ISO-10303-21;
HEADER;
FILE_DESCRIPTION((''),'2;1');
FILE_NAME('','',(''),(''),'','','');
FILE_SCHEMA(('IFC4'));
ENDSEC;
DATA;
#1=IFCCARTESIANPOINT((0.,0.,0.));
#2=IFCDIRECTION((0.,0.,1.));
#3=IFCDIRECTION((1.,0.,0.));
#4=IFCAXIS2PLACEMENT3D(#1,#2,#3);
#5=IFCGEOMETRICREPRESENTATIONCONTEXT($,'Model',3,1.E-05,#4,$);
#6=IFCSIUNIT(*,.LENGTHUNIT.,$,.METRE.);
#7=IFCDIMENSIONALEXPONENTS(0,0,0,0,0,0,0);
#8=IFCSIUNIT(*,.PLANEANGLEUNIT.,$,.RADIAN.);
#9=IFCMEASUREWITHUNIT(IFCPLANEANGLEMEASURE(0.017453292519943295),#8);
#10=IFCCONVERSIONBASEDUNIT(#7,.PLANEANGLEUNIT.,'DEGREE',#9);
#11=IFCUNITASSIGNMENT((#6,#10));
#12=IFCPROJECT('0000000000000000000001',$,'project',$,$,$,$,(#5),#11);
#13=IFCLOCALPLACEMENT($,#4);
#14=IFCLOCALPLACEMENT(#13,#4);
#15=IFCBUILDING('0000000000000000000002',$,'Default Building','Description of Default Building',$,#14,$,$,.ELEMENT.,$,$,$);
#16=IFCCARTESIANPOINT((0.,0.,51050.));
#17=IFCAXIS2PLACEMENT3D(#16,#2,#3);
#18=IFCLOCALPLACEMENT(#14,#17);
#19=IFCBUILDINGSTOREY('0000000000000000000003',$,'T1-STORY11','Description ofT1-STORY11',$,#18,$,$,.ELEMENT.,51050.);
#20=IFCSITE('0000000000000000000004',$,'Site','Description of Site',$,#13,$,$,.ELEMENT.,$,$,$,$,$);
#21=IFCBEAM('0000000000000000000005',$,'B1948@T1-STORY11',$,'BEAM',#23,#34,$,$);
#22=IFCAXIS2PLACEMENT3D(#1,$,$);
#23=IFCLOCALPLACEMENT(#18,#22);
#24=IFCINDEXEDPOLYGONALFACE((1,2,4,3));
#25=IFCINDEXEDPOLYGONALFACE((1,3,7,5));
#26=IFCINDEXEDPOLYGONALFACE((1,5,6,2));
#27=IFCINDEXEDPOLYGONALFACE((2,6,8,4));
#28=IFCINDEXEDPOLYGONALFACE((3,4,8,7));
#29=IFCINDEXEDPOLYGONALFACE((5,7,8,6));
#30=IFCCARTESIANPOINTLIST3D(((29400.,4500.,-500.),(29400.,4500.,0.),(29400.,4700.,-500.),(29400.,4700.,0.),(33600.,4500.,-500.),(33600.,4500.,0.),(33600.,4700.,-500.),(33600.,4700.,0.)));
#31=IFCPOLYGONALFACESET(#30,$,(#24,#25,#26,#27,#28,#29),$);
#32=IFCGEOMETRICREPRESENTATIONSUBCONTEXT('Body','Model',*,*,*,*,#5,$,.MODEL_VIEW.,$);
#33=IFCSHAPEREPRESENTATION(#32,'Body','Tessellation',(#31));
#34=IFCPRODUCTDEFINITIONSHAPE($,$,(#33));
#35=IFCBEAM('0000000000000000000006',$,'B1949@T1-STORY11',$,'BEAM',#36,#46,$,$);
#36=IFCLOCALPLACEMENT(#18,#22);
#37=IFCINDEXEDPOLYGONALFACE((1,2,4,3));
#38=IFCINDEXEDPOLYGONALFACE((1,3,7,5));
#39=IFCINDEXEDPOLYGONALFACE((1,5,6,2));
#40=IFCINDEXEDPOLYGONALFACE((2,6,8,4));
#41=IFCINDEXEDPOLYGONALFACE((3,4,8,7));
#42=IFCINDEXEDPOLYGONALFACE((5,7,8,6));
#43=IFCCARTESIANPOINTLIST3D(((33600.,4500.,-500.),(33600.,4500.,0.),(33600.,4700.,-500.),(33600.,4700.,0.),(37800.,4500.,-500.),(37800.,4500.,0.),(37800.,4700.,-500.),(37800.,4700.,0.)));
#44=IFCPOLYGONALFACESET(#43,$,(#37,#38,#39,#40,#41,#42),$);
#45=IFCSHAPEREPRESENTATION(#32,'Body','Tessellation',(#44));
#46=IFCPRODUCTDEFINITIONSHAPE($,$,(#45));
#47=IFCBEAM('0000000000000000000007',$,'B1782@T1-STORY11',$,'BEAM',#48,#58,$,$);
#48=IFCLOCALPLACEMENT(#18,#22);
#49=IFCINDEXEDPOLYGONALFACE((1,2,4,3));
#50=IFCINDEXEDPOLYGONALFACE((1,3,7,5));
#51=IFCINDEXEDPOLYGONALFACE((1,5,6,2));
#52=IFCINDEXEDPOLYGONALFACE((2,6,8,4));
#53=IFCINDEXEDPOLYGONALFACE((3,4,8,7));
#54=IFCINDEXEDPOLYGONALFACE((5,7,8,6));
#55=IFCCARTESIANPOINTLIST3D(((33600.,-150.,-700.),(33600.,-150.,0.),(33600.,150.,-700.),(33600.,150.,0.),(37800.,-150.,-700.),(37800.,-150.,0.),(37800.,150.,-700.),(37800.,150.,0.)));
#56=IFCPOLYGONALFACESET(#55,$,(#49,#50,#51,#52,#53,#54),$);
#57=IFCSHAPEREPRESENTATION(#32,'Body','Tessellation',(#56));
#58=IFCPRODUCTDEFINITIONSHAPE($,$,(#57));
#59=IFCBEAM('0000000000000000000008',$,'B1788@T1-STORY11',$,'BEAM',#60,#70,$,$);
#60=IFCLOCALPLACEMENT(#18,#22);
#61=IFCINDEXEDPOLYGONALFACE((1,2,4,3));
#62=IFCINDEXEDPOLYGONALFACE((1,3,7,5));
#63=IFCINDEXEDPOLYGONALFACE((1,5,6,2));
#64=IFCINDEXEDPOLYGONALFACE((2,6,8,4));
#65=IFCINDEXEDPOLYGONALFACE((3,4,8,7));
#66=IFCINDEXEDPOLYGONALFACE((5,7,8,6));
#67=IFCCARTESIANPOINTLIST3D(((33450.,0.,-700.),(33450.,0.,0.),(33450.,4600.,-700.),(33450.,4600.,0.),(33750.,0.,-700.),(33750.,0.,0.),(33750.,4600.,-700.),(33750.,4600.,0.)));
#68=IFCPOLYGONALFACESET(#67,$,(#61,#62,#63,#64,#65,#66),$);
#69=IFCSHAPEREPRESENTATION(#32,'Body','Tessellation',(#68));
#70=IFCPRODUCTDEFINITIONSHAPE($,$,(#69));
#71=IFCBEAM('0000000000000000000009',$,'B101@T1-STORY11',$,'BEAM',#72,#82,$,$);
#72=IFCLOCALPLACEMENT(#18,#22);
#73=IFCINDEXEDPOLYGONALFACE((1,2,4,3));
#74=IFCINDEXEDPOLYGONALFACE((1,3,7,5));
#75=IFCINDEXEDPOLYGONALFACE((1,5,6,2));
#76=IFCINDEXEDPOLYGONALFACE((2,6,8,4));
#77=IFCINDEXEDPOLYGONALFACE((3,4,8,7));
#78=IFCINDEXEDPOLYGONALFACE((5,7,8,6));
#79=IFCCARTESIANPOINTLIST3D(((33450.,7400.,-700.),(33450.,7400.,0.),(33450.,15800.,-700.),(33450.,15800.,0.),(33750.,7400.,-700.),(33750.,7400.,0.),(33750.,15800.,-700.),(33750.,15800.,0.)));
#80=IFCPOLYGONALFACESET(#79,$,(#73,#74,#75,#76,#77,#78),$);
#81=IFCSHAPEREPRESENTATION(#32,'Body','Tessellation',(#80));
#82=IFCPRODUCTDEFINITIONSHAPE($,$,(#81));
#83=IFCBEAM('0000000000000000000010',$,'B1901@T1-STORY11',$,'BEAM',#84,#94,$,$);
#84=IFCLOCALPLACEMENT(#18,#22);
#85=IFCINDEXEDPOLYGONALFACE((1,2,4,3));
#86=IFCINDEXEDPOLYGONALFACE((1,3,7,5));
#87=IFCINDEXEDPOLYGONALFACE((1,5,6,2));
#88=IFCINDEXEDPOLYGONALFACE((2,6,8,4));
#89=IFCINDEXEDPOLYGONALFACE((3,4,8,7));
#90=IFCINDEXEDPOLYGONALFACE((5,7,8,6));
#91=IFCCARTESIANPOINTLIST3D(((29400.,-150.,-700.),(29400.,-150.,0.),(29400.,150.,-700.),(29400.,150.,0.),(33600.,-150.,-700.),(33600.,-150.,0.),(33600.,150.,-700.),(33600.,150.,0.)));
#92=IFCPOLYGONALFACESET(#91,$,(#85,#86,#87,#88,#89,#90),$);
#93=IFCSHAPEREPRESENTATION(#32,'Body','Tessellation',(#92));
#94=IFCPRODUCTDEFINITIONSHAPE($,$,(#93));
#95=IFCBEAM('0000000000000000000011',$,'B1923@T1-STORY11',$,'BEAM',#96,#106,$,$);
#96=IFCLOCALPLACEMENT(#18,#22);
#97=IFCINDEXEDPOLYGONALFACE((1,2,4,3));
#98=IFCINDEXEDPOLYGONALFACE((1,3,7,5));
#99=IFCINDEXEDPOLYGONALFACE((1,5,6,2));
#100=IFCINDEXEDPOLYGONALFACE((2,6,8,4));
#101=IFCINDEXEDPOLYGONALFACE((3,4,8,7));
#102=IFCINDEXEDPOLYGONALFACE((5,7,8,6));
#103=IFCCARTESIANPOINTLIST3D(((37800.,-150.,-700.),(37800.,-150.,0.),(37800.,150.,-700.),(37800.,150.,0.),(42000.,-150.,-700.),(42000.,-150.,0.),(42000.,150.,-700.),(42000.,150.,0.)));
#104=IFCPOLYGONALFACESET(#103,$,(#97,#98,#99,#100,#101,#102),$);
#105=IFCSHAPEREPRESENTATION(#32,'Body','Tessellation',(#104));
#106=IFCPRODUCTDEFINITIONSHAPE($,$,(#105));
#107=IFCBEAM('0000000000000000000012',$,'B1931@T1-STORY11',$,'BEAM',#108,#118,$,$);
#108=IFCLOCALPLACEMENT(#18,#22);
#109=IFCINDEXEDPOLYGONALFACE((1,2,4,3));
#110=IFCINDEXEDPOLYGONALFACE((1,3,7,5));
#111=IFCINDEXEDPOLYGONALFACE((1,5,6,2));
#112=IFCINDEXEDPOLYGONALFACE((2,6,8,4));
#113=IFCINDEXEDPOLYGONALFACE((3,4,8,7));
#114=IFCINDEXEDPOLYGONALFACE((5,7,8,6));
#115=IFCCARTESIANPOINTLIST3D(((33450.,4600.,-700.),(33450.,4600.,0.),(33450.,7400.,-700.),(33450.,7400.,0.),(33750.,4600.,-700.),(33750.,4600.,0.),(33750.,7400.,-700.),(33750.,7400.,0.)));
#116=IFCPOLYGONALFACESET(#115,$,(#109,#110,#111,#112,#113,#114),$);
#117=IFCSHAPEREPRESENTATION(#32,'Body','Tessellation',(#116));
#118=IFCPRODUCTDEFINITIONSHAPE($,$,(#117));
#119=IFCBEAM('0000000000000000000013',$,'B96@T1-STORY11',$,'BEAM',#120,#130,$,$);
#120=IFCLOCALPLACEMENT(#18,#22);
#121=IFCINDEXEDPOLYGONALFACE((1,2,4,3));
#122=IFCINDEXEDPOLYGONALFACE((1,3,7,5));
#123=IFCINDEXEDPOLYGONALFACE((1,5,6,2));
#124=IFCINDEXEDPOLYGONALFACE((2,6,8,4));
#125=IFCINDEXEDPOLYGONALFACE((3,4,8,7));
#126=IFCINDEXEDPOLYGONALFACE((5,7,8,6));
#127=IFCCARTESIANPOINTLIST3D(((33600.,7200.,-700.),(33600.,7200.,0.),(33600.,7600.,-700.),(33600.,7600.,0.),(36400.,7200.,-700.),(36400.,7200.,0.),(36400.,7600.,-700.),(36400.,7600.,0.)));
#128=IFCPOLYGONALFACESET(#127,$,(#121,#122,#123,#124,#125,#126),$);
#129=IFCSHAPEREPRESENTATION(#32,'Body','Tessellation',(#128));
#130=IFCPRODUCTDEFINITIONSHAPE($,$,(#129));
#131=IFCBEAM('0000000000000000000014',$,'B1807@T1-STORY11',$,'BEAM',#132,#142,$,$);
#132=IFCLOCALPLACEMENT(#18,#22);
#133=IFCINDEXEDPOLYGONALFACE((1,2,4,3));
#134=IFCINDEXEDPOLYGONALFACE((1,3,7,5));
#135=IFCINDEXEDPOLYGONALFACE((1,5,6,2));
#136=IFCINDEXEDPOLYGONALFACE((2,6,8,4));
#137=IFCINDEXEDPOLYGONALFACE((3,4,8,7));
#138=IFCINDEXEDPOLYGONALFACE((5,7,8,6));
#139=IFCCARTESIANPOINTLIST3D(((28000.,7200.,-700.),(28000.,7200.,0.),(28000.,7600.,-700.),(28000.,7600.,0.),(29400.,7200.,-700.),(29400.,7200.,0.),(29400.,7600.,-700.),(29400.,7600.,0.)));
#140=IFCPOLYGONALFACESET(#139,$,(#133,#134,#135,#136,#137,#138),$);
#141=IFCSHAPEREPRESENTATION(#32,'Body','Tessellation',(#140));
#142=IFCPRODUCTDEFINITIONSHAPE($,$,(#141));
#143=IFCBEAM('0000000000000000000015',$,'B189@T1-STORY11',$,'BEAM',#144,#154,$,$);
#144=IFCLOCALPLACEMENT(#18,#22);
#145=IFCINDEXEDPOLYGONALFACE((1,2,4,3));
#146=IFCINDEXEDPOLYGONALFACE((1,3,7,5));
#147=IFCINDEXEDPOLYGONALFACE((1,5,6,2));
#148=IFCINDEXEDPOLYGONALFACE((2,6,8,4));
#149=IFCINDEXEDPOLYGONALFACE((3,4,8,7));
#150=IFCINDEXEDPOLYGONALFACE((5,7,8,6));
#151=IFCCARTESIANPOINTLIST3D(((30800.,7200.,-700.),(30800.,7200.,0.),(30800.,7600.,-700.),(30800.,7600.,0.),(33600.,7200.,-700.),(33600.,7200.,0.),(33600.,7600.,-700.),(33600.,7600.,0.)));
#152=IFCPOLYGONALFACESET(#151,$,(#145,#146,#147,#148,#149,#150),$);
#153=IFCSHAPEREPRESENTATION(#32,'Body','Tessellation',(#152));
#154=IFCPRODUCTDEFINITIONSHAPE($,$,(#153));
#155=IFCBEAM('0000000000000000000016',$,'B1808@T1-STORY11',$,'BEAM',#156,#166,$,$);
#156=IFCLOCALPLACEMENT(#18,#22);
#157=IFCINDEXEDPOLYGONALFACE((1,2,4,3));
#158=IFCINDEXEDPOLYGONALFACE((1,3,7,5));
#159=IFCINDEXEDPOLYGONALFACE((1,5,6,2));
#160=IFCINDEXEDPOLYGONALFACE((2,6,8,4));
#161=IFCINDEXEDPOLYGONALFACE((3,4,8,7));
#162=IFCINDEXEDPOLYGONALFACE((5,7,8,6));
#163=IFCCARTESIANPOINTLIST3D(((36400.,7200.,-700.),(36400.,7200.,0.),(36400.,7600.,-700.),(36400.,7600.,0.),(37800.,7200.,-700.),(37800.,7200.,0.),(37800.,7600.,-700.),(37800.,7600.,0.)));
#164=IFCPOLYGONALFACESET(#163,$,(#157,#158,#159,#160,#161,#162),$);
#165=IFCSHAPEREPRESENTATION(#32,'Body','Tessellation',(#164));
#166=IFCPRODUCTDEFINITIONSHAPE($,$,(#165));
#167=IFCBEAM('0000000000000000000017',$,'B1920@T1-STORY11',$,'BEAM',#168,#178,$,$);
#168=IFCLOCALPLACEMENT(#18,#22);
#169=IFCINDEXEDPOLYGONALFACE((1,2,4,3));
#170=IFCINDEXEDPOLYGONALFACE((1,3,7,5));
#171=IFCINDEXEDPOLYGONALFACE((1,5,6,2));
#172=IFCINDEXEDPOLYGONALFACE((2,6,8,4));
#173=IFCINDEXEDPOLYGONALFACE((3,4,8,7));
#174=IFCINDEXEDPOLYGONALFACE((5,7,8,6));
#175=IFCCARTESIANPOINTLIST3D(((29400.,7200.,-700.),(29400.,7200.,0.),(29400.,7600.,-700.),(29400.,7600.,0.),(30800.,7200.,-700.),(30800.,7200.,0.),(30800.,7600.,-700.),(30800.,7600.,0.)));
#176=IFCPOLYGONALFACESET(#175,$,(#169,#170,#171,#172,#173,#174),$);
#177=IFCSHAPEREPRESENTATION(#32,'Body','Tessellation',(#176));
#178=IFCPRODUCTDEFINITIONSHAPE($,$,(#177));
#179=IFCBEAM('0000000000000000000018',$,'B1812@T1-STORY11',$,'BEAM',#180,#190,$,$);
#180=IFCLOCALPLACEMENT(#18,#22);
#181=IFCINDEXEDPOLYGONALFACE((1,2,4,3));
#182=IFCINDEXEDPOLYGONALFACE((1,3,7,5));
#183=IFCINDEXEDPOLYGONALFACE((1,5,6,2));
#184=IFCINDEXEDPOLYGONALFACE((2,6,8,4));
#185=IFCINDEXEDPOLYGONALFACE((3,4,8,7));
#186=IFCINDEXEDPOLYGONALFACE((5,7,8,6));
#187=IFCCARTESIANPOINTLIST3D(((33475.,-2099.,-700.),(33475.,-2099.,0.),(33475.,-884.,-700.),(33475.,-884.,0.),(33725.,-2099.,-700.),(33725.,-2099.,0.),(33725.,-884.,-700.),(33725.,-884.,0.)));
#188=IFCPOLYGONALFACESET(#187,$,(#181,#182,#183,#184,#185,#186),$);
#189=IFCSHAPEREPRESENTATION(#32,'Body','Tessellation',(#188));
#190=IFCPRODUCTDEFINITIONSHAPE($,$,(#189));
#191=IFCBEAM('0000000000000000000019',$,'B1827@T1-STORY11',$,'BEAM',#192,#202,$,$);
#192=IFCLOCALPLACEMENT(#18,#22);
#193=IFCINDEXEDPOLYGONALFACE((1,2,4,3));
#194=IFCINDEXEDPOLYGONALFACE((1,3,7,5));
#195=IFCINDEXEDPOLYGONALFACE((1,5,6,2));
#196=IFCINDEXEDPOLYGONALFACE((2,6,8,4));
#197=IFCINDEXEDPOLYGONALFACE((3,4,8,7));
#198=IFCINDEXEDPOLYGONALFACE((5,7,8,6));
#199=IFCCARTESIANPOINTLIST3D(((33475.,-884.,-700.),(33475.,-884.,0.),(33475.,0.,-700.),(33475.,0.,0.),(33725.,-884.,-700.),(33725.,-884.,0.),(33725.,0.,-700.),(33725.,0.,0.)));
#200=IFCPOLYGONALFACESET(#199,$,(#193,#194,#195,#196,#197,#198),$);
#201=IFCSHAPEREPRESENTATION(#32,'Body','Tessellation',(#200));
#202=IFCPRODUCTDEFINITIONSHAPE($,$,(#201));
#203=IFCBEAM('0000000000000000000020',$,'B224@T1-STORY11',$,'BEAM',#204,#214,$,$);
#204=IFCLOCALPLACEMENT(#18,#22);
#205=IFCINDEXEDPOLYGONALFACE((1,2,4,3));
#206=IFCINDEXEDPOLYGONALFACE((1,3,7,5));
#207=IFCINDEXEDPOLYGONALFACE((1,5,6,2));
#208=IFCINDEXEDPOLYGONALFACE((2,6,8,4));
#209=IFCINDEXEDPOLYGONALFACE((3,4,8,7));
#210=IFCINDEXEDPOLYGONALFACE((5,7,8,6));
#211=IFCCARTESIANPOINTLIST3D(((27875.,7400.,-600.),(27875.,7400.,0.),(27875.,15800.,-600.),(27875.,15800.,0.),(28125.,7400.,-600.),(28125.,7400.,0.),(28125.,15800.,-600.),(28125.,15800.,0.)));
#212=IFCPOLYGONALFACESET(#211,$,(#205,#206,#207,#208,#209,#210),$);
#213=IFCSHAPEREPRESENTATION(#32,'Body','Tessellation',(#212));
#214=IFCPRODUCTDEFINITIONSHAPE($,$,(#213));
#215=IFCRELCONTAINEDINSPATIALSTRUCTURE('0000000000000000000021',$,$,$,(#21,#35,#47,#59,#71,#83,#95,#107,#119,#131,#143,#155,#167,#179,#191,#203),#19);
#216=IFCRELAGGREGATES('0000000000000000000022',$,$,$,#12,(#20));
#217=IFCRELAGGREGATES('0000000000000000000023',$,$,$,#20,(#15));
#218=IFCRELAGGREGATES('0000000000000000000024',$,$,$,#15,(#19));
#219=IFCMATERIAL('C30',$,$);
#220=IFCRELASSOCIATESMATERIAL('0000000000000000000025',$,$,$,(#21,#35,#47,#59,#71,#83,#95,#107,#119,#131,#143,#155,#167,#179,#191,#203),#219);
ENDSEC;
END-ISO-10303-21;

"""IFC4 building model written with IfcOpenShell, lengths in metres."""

from ifc_helpers import new_model, entity, si_unit, converted_unit, frame, origin_with_axes, place, context, subcontext, project, spatial, rectangle, extrude, material, element, save


model = new_model("IFC4")

# Units and contexts
model_context = context("Model", 3, precision=1e-05, world=origin_with_axes())
body_context = subcontext(model_context, "Body", "Model", "MODEL_VIEW")
ifc_project = project(units=[si_unit("LENGTHUNIT", "METRE"), converted_unit("PLANEANGLEUNIT", "DEGREE", entity("IfcPlaneAngleMeasure", 0.017453292519943295), si_unit("PLANEANGLEUNIT", "RADIAN"), dimensions=[0, 0, 0, 0, 0, 0, 0])], contexts=[model_context])

# Site, building, storey
site_placement = place(None, origin_with_axes())
site = spatial("IfcSite", under=ifc_project, at=site_placement, Name="Site", Description="Description of Site", CompositionType="ELEMENT")
building_placement = place(site_placement, origin_with_axes())
building = spatial("IfcBuilding", under=site, at=building_placement, Name="Default Building", Description="Description of Default Building", CompositionType="ELEMENT")
storey_placement = place(building_placement, frame((0.0, 0.0, 51050.0), z_axis=(0.0, 0.0, 1.0), x_axis=(1.0, 0.0, 0.0)))
storey = spatial("IfcBuildingStorey", under=building, at=storey_placement, Name="T1-STORY11", Description="Description ofT1-STORY11", CompositionType="ELEMENT", Elevation=51050.0)

# Beams
ifc_material_1 = material(Name="C30")
for number, where, z_axis, x_axis, name in (
    (1, (29400.0, 4600.0, -250.0), (1.0, 0.0, 0.0), (0.0, 1.0, 0.0), "B1948@T1-STORY11"),
    (2, (33600.0, 4600.0, -250.0), (1.0, 0.0, 0.0), (0.0, 1.0, 0.0), "B1949@T1-STORY11"),
):
    element("IfcBeam", number, at=place(storey_placement, frame(where, z_axis=z_axis, x_axis=x_axis)), inside=storey, material=ifc_material_1, Name=name, ObjectType="BEAM", context=body_context, shape_type="SweptSolid", body=[
        extrude(rectangle(XDim=200.0, YDim=500.0), origin_with_axes(), (0.0, 0.0, 1.0), 4200.0),
    ])
beam_1_placement = place(storey_placement, frame((33600.0, 0.0, -350.0), z_axis=(1.0, 0.0, 0.0), x_axis=(0.0, 1.0, 0.0)))
element("IfcBeam", 3, at=beam_1_placement, inside=storey, material=ifc_material_1, Name="B1782@T1-STORY11", ObjectType="BEAM", context=body_context, shape_type="SweptSolid", body=[
    extrude(rectangle(XDim=300.0, YDim=700.0), origin_with_axes(), (0.0, 0.0, 1.0), 4200.0),
])
beam_2_placement = place(storey_placement, frame((33600.0, 0.0, -350.0), z_axis=(0.0, 1.0, 0.0), x_axis=(-1.0, 0.0, 0.0)))
element("IfcBeam", 4, at=beam_2_placement, inside=storey, material=ifc_material_1, Name="B1788@T1-STORY11", ObjectType="BEAM", context=body_context, shape_type="SweptSolid", body=[
    extrude(rectangle(XDim=300.0, YDim=700.0), origin_with_axes(), (0.0, 0.0, 1.0), 4600.0),
])
beam_3_placement = place(storey_placement, frame((33600.0, 7400.0, -350.0), z_axis=(0.0, 1.0, 0.0), x_axis=(-1.0, 0.0, 0.0)))
element("IfcBeam", 5, at=beam_3_placement, inside=storey, material=ifc_material_1, Name="B101@T1-STORY11", ObjectType="BEAM", context=body_context, shape_type="SweptSolid", body=[
    extrude(rectangle(XDim=300.0, YDim=700.0), origin_with_axes(), (0.0, 0.0, 1.0), 8400.0),
])
for number, where, z_axis, x_axis, name in (
    (6, (29400.0, 0.0, -350.0), (1.0, 0.0, 0.0), (0.0, 1.0, 0.0), "B1901@T1-STORY11"),
    (7, (37800.0, 0.0, -350.0), (1.0, 0.0, 0.0), (0.0, 1.0, 0.0), "B1923@T1-STORY11"),
):
    element("IfcBeam", number, at=place(storey_placement, frame(where, z_axis=z_axis, x_axis=x_axis)), inside=storey, material=ifc_material_1, Name=name, ObjectType="BEAM", context=body_context, shape_type="SweptSolid", body=[
        extrude(rectangle(XDim=300.0, YDim=700.0), origin_with_axes(), (0.0, 0.0, 1.0), 4200.0),
    ])
beam_4_placement = place(storey_placement, frame((33600.0, 4600.0, -350.0), z_axis=(0.0, 1.0, 0.0), x_axis=(-1.0, 0.0, 0.0)))
element("IfcBeam", 8, at=beam_4_placement, inside=storey, material=ifc_material_1, Name="B1931@T1-STORY11", ObjectType="BEAM", context=body_context, shape_type="SweptSolid", body=[
    extrude(rectangle(XDim=300.0, YDim=700.0), origin_with_axes(), (0.0, 0.0, 1.0), 2800.0),
])
beam_5_placement = place(storey_placement, frame((33600.0, 7400.0, -350.0), z_axis=(1.0, 0.0, 0.0), x_axis=(0.0, 1.0, 0.0)))
element("IfcBeam", 9, at=beam_5_placement, inside=storey, material=ifc_material_1, Name="B96@T1-STORY11", ObjectType="BEAM", context=body_context, shape_type="SweptSolid", body=[
    extrude(rectangle(XDim=400.0, YDim=700.0), origin_with_axes(), (0.0, 0.0, 1.0), 2800.0),
])
beam_6_placement = place(storey_placement, frame((28000.0, 7400.0, -350.0), z_axis=(1.0, 0.0, 0.0), x_axis=(0.0, 1.0, 0.0)))
element("IfcBeam", 10, at=beam_6_placement, inside=storey, material=ifc_material_1, Name="B1807@T1-STORY11", ObjectType="BEAM", context=body_context, shape_type="SweptSolid", body=[
    extrude(rectangle(XDim=400.0, YDim=700.0), origin_with_axes(), (0.0, 0.0, 1.0), 1400.0),
])
beam_7_placement = place(storey_placement, frame((30800.0, 7400.0, -350.0), z_axis=(1.0, 0.0, 0.0), x_axis=(0.0, 1.0, 0.0)))
element("IfcBeam", 11, at=beam_7_placement, inside=storey, material=ifc_material_1, Name="B189@T1-STORY11", ObjectType="BEAM", context=body_context, shape_type="SweptSolid", body=[
    extrude(rectangle(XDim=400.0, YDim=700.0), origin_with_axes(), (0.0, 0.0, 1.0), 2800.0),
])
for number, where, z_axis, x_axis, name in (
    (12, (36400.0, 7400.0, -350.0), (1.0, 0.0, 0.0), (0.0, 1.0, 0.0), "B1808@T1-STORY11"),
    (13, (29400.0, 7400.0, -350.0), (1.0, 0.0, 0.0), (0.0, 1.0, 0.0), "B1920@T1-STORY11"),
):
    element("IfcBeam", number, at=place(storey_placement, frame(where, z_axis=z_axis, x_axis=x_axis)), inside=storey, material=ifc_material_1, Name=name, ObjectType="BEAM", context=body_context, shape_type="SweptSolid", body=[
        extrude(rectangle(XDim=400.0, YDim=700.0), origin_with_axes(), (0.0, 0.0, 1.0), 1400.0),
    ])
beam_8_placement = place(storey_placement, frame((33600.0, -2099.0, -350.0), z_axis=(0.0, 1.0, 0.0), x_axis=(-1.0, 0.0, 0.0)))
element("IfcBeam", 14, at=beam_8_placement, inside=storey, material=ifc_material_1, Name="B1812@T1-STORY11", ObjectType="BEAM", context=body_context, shape_type="SweptSolid", body=[
    extrude(rectangle(XDim=250.0, YDim=700.0), origin_with_axes(), (0.0, 0.0, 1.0), 1215.0),
])
beam_9_placement = place(storey_placement, frame((33600.0, -884.0, -350.0), z_axis=(0.0, 1.0, 0.0), x_axis=(-1.0, 0.0, 0.0)))
element("IfcBeam", 15, at=beam_9_placement, inside=storey, material=ifc_material_1, Name="B1827@T1-STORY11", ObjectType="BEAM", context=body_context, shape_type="SweptSolid", body=[
    extrude(rectangle(XDim=250.0, YDim=700.0), origin_with_axes(), (0.0, 0.0, 1.0), 884.0),
])
for number, where, z_axis, x_axis, name in (
    (16, (28000.0, 7400.0, -300.0), (0.0, 1.0, 0.0), (-1.0, 0.0, 0.0), "B224@T1-STORY11"),
):
    element("IfcBeam", number, at=place(storey_placement, frame(where, z_axis=z_axis, x_axis=x_axis)), inside=storey, material=ifc_material_1, Name=name, ObjectType="BEAM", context=body_context, shape_type="SweptSolid", body=[
        extrude(rectangle(XDim=250.0, YDim=600.0), origin_with_axes(), (0.0, 0.0, 1.0), 8400.0),
    ])

save(model, "model.ifc")
